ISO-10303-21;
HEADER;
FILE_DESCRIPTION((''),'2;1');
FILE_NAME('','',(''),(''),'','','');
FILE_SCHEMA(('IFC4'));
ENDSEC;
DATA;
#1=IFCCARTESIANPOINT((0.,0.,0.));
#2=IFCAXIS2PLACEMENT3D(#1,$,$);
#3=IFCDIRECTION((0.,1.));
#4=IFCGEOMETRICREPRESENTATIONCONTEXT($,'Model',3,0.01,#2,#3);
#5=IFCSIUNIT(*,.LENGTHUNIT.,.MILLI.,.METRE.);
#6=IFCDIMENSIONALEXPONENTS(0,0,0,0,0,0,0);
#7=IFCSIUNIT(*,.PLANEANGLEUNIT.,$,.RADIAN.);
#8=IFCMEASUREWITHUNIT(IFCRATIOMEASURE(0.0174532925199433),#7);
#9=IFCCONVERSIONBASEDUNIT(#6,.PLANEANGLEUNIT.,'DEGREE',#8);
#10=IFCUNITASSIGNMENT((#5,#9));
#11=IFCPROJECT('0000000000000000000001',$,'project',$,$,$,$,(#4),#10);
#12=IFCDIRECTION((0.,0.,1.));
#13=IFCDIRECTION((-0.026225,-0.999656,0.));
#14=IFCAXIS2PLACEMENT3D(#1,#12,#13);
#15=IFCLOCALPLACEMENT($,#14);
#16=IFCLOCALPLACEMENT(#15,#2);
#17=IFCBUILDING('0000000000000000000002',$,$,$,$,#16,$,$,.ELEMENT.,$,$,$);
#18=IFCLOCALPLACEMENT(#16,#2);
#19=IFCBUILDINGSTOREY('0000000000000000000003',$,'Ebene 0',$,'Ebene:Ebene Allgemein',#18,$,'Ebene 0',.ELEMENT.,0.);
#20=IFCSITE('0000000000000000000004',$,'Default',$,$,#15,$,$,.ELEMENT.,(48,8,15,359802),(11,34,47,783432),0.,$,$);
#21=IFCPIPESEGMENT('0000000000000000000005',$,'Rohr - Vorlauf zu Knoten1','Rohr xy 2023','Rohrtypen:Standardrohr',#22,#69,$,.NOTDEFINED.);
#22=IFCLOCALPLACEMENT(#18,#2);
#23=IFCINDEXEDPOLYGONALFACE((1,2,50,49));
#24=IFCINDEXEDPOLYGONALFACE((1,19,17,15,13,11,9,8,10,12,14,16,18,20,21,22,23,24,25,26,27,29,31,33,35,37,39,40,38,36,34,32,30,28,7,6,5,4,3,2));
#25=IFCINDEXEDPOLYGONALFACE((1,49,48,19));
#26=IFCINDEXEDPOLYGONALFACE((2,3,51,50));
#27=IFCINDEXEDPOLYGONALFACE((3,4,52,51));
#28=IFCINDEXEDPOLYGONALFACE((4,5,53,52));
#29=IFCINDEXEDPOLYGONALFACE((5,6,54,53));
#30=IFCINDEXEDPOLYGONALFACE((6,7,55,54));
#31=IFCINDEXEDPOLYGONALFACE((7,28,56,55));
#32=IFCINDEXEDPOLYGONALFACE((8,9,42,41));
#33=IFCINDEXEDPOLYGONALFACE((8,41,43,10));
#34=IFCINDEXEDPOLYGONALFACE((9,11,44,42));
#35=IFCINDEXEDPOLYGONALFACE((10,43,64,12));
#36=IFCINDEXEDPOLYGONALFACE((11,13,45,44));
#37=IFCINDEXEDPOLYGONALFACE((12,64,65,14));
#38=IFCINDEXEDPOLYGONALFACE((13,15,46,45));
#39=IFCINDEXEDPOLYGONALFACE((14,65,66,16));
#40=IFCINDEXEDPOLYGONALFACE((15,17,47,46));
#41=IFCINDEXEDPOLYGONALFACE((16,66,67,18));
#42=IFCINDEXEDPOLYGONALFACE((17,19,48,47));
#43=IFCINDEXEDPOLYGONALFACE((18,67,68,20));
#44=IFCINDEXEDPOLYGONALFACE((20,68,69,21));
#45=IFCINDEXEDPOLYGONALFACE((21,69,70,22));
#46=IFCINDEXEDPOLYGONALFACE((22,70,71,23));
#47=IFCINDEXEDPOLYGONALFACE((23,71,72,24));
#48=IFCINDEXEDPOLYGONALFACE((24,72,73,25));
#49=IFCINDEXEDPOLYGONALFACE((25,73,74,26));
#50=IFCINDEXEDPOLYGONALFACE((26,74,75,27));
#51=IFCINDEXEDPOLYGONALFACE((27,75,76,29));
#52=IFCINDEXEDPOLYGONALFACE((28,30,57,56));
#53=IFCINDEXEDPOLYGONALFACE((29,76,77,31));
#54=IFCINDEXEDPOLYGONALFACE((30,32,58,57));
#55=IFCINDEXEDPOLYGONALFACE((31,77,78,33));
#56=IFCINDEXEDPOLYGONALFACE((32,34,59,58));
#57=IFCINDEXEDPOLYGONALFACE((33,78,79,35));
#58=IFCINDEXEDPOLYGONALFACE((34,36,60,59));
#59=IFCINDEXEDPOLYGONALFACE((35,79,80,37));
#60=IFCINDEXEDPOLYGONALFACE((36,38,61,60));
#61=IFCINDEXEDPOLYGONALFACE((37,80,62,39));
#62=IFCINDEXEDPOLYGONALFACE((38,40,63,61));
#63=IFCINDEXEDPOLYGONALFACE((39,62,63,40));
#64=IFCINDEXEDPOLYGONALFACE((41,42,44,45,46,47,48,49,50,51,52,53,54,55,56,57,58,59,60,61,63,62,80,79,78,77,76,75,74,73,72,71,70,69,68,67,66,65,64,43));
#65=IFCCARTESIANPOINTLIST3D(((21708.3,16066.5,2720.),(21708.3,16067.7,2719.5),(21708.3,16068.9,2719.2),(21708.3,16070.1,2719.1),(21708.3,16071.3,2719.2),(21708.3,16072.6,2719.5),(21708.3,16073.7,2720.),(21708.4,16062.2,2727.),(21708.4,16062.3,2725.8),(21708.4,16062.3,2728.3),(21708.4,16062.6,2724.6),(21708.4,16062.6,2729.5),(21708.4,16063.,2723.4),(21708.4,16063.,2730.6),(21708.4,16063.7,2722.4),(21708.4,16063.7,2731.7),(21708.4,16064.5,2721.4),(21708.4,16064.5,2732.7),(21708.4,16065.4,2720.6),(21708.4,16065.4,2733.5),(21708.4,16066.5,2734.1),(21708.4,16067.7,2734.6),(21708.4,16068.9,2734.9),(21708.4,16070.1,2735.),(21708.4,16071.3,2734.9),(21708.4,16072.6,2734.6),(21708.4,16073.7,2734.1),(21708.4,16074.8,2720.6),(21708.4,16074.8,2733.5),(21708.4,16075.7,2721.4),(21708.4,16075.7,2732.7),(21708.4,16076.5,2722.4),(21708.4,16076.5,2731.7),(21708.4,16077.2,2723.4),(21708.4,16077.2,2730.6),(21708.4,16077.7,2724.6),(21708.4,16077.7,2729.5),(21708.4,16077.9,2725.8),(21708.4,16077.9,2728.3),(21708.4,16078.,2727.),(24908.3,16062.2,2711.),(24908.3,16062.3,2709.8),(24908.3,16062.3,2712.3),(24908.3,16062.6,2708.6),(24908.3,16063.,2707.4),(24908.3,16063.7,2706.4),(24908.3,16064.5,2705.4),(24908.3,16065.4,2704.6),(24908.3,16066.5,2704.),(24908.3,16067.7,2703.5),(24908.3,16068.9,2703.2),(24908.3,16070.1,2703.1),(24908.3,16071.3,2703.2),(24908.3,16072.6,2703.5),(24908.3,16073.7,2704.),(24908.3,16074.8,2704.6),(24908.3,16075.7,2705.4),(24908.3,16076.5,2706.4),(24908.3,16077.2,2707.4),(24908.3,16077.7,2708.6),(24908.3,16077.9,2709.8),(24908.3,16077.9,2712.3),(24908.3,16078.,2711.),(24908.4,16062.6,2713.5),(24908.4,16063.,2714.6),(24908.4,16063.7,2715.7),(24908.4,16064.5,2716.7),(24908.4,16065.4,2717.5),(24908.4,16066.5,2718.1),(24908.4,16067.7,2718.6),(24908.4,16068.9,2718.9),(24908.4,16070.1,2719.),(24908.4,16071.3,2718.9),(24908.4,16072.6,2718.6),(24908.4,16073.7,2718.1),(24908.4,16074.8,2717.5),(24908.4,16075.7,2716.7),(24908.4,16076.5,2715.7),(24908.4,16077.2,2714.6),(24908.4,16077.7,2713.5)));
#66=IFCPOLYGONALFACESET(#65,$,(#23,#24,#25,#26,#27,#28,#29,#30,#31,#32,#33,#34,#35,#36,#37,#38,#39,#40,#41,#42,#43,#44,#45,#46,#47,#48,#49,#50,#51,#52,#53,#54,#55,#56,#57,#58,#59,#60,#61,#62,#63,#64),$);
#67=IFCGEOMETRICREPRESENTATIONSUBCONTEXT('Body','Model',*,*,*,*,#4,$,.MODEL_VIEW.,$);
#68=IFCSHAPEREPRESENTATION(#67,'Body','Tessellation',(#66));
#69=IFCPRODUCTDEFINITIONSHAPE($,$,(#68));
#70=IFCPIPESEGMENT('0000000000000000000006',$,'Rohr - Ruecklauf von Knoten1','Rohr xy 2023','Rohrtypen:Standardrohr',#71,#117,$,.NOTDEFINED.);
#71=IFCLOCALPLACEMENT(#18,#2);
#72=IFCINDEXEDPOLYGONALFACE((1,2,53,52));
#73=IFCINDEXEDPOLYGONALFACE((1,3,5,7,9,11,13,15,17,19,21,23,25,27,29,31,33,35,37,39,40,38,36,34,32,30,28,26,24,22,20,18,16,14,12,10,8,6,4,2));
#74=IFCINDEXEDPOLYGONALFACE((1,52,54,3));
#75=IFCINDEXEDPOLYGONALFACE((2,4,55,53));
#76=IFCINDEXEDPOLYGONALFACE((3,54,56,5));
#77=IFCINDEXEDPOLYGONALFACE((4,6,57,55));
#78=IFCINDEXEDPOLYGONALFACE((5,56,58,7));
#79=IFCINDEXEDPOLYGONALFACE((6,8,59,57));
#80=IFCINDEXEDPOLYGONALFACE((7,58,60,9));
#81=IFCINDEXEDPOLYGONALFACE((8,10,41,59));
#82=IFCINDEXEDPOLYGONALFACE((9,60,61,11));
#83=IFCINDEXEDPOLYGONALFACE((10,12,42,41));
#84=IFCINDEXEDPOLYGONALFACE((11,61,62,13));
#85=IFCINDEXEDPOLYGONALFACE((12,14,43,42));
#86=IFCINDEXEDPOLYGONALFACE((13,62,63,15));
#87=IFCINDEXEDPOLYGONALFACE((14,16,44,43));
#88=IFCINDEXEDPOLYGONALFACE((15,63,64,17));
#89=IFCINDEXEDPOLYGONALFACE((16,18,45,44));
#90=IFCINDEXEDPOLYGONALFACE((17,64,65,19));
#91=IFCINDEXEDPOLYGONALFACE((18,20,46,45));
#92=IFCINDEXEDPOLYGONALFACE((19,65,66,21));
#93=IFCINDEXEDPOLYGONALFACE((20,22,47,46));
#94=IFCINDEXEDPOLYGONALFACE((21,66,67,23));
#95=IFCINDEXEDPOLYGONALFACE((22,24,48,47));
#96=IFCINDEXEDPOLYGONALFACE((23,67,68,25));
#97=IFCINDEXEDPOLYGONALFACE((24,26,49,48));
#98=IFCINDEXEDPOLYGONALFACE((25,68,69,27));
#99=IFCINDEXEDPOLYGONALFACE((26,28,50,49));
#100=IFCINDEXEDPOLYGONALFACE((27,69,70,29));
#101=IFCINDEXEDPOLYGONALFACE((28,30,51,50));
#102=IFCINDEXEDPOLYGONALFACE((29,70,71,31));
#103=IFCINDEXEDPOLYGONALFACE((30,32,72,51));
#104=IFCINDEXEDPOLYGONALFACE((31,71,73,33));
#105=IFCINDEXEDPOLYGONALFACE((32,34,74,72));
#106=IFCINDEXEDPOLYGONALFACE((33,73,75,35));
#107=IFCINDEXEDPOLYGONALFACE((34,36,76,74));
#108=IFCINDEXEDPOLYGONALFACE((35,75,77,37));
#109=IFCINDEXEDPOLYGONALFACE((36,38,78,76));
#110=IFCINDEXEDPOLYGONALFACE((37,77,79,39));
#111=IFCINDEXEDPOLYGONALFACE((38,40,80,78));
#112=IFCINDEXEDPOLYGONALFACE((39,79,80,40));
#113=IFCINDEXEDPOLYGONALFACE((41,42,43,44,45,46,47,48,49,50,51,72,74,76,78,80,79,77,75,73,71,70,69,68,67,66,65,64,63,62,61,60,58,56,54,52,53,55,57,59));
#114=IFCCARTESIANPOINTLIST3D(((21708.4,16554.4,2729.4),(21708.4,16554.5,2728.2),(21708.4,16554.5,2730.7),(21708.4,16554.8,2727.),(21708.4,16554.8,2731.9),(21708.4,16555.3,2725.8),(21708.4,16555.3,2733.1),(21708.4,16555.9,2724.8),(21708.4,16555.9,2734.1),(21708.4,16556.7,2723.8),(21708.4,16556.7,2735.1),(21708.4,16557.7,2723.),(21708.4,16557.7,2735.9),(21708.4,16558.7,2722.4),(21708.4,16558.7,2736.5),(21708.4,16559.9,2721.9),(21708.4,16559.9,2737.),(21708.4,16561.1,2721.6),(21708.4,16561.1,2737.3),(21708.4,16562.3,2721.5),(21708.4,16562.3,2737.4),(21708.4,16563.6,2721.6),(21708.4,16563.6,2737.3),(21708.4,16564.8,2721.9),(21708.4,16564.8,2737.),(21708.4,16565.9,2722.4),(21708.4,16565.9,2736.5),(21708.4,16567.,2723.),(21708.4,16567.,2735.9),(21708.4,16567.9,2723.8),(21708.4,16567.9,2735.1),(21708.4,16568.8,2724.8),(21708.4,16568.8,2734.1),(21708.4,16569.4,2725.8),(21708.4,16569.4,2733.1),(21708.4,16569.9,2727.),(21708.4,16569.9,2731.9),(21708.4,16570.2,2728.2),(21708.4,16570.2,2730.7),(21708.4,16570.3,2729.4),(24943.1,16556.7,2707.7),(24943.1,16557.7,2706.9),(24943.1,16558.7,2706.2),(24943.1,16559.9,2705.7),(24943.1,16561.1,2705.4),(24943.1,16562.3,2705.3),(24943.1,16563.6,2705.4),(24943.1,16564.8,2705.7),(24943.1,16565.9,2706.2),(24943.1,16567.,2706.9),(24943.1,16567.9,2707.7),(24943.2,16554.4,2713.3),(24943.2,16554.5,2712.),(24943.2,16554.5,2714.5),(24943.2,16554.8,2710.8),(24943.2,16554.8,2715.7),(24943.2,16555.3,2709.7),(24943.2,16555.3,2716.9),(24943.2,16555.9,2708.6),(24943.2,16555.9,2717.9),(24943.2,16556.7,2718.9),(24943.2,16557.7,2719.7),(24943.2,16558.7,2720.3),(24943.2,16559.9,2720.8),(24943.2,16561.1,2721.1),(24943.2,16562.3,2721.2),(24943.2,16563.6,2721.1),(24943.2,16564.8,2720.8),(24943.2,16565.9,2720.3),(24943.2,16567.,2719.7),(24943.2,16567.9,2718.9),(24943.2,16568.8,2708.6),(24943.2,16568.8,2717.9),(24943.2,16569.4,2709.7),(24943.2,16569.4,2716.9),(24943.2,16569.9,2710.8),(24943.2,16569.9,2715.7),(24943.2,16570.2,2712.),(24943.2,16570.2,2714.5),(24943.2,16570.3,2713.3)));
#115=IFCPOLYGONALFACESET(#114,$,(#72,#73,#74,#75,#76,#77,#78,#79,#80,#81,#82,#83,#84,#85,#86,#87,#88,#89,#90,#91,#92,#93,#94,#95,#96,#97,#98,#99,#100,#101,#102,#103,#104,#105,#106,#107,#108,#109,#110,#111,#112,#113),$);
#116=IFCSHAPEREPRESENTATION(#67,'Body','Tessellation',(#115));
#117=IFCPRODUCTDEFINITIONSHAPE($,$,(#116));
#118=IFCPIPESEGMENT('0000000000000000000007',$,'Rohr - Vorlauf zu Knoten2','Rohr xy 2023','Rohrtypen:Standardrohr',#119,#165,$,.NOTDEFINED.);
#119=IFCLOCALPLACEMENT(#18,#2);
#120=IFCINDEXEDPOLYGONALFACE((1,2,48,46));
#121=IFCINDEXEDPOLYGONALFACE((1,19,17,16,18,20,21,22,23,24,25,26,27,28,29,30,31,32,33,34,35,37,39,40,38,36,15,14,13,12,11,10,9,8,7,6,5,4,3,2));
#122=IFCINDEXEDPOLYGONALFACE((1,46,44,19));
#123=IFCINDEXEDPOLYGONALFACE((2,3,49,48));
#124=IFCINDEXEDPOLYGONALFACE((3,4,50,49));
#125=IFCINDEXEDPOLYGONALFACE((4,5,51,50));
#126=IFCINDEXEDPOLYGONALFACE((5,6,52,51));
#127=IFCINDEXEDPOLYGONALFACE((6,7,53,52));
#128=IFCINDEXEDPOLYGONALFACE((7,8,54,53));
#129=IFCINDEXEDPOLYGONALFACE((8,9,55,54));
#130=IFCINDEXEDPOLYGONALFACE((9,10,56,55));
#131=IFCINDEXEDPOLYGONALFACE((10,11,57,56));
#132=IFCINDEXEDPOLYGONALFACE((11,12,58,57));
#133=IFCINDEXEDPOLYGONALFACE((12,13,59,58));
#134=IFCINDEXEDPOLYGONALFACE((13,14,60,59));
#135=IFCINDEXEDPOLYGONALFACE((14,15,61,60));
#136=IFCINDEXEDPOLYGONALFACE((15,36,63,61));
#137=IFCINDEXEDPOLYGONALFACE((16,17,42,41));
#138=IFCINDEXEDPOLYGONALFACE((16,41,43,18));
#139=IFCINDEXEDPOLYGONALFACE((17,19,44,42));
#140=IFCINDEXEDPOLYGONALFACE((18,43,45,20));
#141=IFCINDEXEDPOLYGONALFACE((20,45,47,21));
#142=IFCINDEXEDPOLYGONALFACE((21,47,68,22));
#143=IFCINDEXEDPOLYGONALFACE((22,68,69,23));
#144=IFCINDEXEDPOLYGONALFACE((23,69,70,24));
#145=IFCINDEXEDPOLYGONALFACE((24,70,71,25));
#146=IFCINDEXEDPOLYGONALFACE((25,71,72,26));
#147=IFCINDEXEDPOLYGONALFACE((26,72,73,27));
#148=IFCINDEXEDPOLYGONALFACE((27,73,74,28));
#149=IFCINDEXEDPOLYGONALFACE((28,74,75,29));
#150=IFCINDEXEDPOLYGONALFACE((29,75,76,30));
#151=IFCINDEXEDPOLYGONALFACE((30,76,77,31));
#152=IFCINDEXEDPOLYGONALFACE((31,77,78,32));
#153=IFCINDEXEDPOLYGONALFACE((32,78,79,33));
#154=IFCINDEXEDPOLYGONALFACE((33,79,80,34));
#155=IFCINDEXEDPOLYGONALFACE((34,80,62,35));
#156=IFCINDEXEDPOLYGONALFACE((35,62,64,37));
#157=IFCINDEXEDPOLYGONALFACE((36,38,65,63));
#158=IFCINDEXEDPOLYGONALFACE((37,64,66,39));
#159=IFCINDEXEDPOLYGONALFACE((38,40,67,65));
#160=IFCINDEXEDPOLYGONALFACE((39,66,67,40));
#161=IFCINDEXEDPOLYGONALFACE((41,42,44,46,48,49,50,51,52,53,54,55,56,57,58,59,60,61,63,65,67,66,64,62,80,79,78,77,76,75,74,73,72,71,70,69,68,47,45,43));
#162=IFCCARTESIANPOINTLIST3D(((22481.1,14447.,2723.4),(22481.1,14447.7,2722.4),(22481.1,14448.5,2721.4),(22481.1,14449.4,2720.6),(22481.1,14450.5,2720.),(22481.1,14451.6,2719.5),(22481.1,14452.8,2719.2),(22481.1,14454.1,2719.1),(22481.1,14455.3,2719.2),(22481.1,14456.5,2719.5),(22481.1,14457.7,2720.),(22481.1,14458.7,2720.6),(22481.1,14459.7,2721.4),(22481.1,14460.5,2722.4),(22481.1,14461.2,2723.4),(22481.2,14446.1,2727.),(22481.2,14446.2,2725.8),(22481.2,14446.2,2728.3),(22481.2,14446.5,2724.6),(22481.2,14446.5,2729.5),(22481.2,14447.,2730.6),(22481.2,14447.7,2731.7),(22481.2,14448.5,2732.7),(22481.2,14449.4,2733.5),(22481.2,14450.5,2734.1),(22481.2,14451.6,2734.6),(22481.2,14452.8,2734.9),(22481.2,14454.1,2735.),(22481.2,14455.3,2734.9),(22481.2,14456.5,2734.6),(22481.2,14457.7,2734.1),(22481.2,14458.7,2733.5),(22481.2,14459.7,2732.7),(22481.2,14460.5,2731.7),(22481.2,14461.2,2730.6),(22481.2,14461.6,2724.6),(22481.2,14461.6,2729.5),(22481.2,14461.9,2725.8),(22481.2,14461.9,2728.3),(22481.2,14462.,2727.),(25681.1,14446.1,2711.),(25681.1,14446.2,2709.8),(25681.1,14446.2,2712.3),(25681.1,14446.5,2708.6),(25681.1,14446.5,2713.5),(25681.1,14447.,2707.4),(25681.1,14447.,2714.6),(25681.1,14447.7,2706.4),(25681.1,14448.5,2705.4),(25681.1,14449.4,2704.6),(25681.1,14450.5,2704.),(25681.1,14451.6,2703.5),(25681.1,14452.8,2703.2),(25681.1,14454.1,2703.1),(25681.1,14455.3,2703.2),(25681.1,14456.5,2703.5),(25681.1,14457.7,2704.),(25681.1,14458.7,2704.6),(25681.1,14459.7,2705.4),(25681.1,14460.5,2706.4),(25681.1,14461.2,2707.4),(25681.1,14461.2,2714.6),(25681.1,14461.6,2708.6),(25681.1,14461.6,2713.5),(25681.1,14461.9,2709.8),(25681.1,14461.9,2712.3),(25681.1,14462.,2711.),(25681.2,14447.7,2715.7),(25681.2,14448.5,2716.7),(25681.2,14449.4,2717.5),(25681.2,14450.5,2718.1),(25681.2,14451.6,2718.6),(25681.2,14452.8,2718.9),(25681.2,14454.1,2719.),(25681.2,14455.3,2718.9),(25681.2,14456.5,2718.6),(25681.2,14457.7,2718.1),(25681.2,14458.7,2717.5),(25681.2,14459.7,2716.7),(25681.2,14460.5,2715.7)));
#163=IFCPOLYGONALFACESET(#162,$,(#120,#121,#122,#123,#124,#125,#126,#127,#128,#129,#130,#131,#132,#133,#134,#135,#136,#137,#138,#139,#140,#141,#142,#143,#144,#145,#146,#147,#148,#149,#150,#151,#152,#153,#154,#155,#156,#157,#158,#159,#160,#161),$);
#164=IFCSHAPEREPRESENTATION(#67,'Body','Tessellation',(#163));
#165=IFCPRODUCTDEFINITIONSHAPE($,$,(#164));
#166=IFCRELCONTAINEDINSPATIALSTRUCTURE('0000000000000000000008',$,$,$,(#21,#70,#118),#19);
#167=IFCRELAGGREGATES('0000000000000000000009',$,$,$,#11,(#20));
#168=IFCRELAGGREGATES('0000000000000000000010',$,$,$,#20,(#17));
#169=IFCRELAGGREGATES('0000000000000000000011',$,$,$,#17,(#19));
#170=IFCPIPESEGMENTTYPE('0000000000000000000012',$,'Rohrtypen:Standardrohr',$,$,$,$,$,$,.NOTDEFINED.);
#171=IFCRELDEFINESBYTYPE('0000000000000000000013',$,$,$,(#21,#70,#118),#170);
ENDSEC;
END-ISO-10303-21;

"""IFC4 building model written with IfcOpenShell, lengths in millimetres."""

from ifc_helpers import new_model, entity, si_unit, converted_unit, direction, frame, origin, place, context, subcontext, project, spatial, indexed_curve, outline, extrude, type_object, element, save


model = new_model("IFC4")

# Units and contexts
model_context = context("Model", 3, precision=0.01, world=origin(), true_north=direction((0.0, 1.0)))
body_context = subcontext(model_context, "Body", "Model", "MODEL_VIEW")
ifc_project = project(units=[si_unit("LENGTHUNIT", "METRE", prefix="MILLI"), converted_unit("PLANEANGLEUNIT", "DEGREE", entity("IfcRatioMeasure", 0.0174532925199433), si_unit("PLANEANGLEUNIT", "RADIAN"), dimensions=[0, 0, 0, 0, 0, 0, 0])], contexts=[model_context])

# Site, building, storey
site_placement = place(None, frame((0.0, 0.0, 0.0), z_axis=(0.0, 0.0, 1.0), x_axis=(-0.026225, -0.999656, 0.0)))
site = spatial("IfcSite", under=ifc_project, at=site_placement, Name="Default", CompositionType="ELEMENT", RefLatitude=(48, 8, 15, 359802), RefLongitude=(11, 34, 47, 783432), RefElevation=0.0)
building_placement = place(site_placement, origin())
building = spatial("IfcBuilding", under=site, at=building_placement, CompositionType="ELEMENT")
storey_placement = place(building_placement, origin())
storey = spatial("IfcBuildingStorey", under=building, at=storey_placement, Name="Ebene 0", ObjectType="Ebene:Ebene Allgemein", LongName="Ebene 0", CompositionType="ELEMENT", Elevation=0.0)

# Pipe segments
pipe_segment_type = type_object("IfcPipeSegmentType", Name="Rohrtypen:Standardrohr", PredefinedType="NOTDEFINED")
pipe_segment_1_placement = place(storey_placement, origin())
element("IfcPipeSegment", 1, at=pipe_segment_1_placement, inside=storey, type_object=pipe_segment_type, Name="Rohr - Vorlauf zu Knoten1", Description="Rohr xy 2023", ObjectType="Rohrtypen:Standardrohr", PredefinedType="NOTDEFINED", context=body_context, shape_type="SweptSolid", body=[
    extrude(outline(indexed_curve([(7.9, 0.0), (7.8, 1.2), (7.6, 2.5), (7.1, 3.6), (6.4, 4.7), (5.6, 5.6), (4.7, 6.4), (3.6, 7.1), (2.5, 7.6), (1.2, 7.8), (0.0, 7.9), (-1.2, 7.8), (-2.5, 7.6), (-3.6, 7.1), (-4.7, 6.4), (-5.6, 5.6), (-6.4, 4.7), (-7.1, 3.6), (-7.6, 2.5), (-7.8, 1.2), (-7.9, 0.0), (-7.8, -1.2), (-7.6, -2.5), (-7.1, -3.6), (-6.4, -4.7), (-5.6, -5.6), (-4.7, -6.4), (-3.6, -7.1), (-2.5, -7.6), (-1.2, -7.8), (0.0, -7.9), (1.2, -7.8), (2.5, -7.6), (3.6, -7.1), (4.7, -6.4), (5.6, -5.6), (6.4, -4.7), (7.1, -3.6), (7.6, -2.5), (7.8, -1.2), (7.9, 0.0)], self_intersect=False)), frame((24908.3, 16070.1, 2711.0), z_axis=(-0.999988, 0.0, 0.005), x_axis=(0.0, 1.0, 0.0)), (0.0, 0.0, 1.0), 3200.0),
])
pipe_segment_2_placement = place(storey_placement, origin())
element("IfcPipeSegment", 2, at=pipe_segment_2_placement, inside=storey, type_object=pipe_segment_type, Name="Rohr - Ruecklauf von Knoten1", Description="Rohr xy 2023", ObjectType="Rohrtypen:Standardrohr", PredefinedType="NOTDEFINED", context=body_context, shape_type="SweptSolid", body=[
    extrude(outline(indexed_curve([(7.9, 0.0), (7.8, 1.2), (7.6, 2.5), (7.1, 3.6), (6.4, 4.7), (5.6, 5.6), (4.7, 6.4), (3.6, 7.1), (2.5, 7.6), (1.2, 7.8), (0.0, 7.9), (-1.2, 7.8), (-2.5, 7.6), (-3.6, 7.1), (-4.7, 6.4), (-5.6, 5.6), (-6.4, 4.7), (-7.1, 3.6), (-7.6, 2.5), (-7.8, 1.2), (-7.9, 0.0), (-7.8, -1.2), (-7.6, -2.5), (-7.1, -3.6), (-6.4, -4.7), (-5.6, -5.6), (-4.7, -6.4), (-3.6, -7.1), (-2.5, -7.6), (-1.2, -7.8), (0.0, -7.9), (1.2, -7.8), (2.5, -7.6), (3.6, -7.1), (4.7, -6.4), (5.6, -5.6), (6.4, -4.7), (7.1, -3.6), (7.6, -2.5), (7.8, -1.2), (7.9, 0.0)], self_intersect=False)), frame((24943.2, 16562.3, 2713.3), z_axis=(-0.999988, 0.0, 0.005), x_axis=(0.0, 1.0, 0.0)), (0.0, 0.0, 1.0), 3234.8),
])
pipe_segment_3_placement = place(storey_placement, origin())
element("IfcPipeSegment", 3, at=pipe_segment_3_placement, inside=storey, type_object=pipe_segment_type, Name="Rohr - Vorlauf zu Knoten2", Description="Rohr xy 2023", ObjectType="Rohrtypen:Standardrohr", PredefinedType="NOTDEFINED", context=body_context, shape_type="SweptSolid", body=[
    extrude(outline(indexed_curve([(7.9, 0.0), (7.8, 1.2), (7.6, 2.5), (7.1, 3.6), (6.4, 4.7), (5.6, 5.6), (4.7, 6.4), (3.6, 7.1), (2.5, 7.6), (1.2, 7.8), (0.0, 7.9), (-1.2, 7.8), (-2.5, 7.6), (-3.6, 7.1), (-4.7, 6.4), (-5.6, 5.6), (-6.4, 4.7), (-7.1, 3.6), (-7.6, 2.5), (-7.8, 1.2), (-7.9, 0.0), (-7.8, -1.2), (-7.6, -2.5), (-7.1, -3.6), (-6.4, -4.7), (-5.6, -5.6), (-4.7, -6.4), (-3.6, -7.1), (-2.5, -7.6), (-1.2, -7.8), (0.0, -7.9), (1.2, -7.8), (2.5, -7.6), (3.6, -7.1), (4.7, -6.4), (5.6, -5.6), (6.4, -4.7), (7.1, -3.6), (7.6, -2.5), (7.8, -1.2), (7.9, 0.0)], self_intersect=False)), frame((25681.1, 14454.1, 2711.0), z_axis=(-0.999988, 0.0, 0.005), x_axis=(0.0, 1.0, 0.0)), (0.0, 0.0, 1.0), 3200.0),
])

save(model, "model.ifc")
